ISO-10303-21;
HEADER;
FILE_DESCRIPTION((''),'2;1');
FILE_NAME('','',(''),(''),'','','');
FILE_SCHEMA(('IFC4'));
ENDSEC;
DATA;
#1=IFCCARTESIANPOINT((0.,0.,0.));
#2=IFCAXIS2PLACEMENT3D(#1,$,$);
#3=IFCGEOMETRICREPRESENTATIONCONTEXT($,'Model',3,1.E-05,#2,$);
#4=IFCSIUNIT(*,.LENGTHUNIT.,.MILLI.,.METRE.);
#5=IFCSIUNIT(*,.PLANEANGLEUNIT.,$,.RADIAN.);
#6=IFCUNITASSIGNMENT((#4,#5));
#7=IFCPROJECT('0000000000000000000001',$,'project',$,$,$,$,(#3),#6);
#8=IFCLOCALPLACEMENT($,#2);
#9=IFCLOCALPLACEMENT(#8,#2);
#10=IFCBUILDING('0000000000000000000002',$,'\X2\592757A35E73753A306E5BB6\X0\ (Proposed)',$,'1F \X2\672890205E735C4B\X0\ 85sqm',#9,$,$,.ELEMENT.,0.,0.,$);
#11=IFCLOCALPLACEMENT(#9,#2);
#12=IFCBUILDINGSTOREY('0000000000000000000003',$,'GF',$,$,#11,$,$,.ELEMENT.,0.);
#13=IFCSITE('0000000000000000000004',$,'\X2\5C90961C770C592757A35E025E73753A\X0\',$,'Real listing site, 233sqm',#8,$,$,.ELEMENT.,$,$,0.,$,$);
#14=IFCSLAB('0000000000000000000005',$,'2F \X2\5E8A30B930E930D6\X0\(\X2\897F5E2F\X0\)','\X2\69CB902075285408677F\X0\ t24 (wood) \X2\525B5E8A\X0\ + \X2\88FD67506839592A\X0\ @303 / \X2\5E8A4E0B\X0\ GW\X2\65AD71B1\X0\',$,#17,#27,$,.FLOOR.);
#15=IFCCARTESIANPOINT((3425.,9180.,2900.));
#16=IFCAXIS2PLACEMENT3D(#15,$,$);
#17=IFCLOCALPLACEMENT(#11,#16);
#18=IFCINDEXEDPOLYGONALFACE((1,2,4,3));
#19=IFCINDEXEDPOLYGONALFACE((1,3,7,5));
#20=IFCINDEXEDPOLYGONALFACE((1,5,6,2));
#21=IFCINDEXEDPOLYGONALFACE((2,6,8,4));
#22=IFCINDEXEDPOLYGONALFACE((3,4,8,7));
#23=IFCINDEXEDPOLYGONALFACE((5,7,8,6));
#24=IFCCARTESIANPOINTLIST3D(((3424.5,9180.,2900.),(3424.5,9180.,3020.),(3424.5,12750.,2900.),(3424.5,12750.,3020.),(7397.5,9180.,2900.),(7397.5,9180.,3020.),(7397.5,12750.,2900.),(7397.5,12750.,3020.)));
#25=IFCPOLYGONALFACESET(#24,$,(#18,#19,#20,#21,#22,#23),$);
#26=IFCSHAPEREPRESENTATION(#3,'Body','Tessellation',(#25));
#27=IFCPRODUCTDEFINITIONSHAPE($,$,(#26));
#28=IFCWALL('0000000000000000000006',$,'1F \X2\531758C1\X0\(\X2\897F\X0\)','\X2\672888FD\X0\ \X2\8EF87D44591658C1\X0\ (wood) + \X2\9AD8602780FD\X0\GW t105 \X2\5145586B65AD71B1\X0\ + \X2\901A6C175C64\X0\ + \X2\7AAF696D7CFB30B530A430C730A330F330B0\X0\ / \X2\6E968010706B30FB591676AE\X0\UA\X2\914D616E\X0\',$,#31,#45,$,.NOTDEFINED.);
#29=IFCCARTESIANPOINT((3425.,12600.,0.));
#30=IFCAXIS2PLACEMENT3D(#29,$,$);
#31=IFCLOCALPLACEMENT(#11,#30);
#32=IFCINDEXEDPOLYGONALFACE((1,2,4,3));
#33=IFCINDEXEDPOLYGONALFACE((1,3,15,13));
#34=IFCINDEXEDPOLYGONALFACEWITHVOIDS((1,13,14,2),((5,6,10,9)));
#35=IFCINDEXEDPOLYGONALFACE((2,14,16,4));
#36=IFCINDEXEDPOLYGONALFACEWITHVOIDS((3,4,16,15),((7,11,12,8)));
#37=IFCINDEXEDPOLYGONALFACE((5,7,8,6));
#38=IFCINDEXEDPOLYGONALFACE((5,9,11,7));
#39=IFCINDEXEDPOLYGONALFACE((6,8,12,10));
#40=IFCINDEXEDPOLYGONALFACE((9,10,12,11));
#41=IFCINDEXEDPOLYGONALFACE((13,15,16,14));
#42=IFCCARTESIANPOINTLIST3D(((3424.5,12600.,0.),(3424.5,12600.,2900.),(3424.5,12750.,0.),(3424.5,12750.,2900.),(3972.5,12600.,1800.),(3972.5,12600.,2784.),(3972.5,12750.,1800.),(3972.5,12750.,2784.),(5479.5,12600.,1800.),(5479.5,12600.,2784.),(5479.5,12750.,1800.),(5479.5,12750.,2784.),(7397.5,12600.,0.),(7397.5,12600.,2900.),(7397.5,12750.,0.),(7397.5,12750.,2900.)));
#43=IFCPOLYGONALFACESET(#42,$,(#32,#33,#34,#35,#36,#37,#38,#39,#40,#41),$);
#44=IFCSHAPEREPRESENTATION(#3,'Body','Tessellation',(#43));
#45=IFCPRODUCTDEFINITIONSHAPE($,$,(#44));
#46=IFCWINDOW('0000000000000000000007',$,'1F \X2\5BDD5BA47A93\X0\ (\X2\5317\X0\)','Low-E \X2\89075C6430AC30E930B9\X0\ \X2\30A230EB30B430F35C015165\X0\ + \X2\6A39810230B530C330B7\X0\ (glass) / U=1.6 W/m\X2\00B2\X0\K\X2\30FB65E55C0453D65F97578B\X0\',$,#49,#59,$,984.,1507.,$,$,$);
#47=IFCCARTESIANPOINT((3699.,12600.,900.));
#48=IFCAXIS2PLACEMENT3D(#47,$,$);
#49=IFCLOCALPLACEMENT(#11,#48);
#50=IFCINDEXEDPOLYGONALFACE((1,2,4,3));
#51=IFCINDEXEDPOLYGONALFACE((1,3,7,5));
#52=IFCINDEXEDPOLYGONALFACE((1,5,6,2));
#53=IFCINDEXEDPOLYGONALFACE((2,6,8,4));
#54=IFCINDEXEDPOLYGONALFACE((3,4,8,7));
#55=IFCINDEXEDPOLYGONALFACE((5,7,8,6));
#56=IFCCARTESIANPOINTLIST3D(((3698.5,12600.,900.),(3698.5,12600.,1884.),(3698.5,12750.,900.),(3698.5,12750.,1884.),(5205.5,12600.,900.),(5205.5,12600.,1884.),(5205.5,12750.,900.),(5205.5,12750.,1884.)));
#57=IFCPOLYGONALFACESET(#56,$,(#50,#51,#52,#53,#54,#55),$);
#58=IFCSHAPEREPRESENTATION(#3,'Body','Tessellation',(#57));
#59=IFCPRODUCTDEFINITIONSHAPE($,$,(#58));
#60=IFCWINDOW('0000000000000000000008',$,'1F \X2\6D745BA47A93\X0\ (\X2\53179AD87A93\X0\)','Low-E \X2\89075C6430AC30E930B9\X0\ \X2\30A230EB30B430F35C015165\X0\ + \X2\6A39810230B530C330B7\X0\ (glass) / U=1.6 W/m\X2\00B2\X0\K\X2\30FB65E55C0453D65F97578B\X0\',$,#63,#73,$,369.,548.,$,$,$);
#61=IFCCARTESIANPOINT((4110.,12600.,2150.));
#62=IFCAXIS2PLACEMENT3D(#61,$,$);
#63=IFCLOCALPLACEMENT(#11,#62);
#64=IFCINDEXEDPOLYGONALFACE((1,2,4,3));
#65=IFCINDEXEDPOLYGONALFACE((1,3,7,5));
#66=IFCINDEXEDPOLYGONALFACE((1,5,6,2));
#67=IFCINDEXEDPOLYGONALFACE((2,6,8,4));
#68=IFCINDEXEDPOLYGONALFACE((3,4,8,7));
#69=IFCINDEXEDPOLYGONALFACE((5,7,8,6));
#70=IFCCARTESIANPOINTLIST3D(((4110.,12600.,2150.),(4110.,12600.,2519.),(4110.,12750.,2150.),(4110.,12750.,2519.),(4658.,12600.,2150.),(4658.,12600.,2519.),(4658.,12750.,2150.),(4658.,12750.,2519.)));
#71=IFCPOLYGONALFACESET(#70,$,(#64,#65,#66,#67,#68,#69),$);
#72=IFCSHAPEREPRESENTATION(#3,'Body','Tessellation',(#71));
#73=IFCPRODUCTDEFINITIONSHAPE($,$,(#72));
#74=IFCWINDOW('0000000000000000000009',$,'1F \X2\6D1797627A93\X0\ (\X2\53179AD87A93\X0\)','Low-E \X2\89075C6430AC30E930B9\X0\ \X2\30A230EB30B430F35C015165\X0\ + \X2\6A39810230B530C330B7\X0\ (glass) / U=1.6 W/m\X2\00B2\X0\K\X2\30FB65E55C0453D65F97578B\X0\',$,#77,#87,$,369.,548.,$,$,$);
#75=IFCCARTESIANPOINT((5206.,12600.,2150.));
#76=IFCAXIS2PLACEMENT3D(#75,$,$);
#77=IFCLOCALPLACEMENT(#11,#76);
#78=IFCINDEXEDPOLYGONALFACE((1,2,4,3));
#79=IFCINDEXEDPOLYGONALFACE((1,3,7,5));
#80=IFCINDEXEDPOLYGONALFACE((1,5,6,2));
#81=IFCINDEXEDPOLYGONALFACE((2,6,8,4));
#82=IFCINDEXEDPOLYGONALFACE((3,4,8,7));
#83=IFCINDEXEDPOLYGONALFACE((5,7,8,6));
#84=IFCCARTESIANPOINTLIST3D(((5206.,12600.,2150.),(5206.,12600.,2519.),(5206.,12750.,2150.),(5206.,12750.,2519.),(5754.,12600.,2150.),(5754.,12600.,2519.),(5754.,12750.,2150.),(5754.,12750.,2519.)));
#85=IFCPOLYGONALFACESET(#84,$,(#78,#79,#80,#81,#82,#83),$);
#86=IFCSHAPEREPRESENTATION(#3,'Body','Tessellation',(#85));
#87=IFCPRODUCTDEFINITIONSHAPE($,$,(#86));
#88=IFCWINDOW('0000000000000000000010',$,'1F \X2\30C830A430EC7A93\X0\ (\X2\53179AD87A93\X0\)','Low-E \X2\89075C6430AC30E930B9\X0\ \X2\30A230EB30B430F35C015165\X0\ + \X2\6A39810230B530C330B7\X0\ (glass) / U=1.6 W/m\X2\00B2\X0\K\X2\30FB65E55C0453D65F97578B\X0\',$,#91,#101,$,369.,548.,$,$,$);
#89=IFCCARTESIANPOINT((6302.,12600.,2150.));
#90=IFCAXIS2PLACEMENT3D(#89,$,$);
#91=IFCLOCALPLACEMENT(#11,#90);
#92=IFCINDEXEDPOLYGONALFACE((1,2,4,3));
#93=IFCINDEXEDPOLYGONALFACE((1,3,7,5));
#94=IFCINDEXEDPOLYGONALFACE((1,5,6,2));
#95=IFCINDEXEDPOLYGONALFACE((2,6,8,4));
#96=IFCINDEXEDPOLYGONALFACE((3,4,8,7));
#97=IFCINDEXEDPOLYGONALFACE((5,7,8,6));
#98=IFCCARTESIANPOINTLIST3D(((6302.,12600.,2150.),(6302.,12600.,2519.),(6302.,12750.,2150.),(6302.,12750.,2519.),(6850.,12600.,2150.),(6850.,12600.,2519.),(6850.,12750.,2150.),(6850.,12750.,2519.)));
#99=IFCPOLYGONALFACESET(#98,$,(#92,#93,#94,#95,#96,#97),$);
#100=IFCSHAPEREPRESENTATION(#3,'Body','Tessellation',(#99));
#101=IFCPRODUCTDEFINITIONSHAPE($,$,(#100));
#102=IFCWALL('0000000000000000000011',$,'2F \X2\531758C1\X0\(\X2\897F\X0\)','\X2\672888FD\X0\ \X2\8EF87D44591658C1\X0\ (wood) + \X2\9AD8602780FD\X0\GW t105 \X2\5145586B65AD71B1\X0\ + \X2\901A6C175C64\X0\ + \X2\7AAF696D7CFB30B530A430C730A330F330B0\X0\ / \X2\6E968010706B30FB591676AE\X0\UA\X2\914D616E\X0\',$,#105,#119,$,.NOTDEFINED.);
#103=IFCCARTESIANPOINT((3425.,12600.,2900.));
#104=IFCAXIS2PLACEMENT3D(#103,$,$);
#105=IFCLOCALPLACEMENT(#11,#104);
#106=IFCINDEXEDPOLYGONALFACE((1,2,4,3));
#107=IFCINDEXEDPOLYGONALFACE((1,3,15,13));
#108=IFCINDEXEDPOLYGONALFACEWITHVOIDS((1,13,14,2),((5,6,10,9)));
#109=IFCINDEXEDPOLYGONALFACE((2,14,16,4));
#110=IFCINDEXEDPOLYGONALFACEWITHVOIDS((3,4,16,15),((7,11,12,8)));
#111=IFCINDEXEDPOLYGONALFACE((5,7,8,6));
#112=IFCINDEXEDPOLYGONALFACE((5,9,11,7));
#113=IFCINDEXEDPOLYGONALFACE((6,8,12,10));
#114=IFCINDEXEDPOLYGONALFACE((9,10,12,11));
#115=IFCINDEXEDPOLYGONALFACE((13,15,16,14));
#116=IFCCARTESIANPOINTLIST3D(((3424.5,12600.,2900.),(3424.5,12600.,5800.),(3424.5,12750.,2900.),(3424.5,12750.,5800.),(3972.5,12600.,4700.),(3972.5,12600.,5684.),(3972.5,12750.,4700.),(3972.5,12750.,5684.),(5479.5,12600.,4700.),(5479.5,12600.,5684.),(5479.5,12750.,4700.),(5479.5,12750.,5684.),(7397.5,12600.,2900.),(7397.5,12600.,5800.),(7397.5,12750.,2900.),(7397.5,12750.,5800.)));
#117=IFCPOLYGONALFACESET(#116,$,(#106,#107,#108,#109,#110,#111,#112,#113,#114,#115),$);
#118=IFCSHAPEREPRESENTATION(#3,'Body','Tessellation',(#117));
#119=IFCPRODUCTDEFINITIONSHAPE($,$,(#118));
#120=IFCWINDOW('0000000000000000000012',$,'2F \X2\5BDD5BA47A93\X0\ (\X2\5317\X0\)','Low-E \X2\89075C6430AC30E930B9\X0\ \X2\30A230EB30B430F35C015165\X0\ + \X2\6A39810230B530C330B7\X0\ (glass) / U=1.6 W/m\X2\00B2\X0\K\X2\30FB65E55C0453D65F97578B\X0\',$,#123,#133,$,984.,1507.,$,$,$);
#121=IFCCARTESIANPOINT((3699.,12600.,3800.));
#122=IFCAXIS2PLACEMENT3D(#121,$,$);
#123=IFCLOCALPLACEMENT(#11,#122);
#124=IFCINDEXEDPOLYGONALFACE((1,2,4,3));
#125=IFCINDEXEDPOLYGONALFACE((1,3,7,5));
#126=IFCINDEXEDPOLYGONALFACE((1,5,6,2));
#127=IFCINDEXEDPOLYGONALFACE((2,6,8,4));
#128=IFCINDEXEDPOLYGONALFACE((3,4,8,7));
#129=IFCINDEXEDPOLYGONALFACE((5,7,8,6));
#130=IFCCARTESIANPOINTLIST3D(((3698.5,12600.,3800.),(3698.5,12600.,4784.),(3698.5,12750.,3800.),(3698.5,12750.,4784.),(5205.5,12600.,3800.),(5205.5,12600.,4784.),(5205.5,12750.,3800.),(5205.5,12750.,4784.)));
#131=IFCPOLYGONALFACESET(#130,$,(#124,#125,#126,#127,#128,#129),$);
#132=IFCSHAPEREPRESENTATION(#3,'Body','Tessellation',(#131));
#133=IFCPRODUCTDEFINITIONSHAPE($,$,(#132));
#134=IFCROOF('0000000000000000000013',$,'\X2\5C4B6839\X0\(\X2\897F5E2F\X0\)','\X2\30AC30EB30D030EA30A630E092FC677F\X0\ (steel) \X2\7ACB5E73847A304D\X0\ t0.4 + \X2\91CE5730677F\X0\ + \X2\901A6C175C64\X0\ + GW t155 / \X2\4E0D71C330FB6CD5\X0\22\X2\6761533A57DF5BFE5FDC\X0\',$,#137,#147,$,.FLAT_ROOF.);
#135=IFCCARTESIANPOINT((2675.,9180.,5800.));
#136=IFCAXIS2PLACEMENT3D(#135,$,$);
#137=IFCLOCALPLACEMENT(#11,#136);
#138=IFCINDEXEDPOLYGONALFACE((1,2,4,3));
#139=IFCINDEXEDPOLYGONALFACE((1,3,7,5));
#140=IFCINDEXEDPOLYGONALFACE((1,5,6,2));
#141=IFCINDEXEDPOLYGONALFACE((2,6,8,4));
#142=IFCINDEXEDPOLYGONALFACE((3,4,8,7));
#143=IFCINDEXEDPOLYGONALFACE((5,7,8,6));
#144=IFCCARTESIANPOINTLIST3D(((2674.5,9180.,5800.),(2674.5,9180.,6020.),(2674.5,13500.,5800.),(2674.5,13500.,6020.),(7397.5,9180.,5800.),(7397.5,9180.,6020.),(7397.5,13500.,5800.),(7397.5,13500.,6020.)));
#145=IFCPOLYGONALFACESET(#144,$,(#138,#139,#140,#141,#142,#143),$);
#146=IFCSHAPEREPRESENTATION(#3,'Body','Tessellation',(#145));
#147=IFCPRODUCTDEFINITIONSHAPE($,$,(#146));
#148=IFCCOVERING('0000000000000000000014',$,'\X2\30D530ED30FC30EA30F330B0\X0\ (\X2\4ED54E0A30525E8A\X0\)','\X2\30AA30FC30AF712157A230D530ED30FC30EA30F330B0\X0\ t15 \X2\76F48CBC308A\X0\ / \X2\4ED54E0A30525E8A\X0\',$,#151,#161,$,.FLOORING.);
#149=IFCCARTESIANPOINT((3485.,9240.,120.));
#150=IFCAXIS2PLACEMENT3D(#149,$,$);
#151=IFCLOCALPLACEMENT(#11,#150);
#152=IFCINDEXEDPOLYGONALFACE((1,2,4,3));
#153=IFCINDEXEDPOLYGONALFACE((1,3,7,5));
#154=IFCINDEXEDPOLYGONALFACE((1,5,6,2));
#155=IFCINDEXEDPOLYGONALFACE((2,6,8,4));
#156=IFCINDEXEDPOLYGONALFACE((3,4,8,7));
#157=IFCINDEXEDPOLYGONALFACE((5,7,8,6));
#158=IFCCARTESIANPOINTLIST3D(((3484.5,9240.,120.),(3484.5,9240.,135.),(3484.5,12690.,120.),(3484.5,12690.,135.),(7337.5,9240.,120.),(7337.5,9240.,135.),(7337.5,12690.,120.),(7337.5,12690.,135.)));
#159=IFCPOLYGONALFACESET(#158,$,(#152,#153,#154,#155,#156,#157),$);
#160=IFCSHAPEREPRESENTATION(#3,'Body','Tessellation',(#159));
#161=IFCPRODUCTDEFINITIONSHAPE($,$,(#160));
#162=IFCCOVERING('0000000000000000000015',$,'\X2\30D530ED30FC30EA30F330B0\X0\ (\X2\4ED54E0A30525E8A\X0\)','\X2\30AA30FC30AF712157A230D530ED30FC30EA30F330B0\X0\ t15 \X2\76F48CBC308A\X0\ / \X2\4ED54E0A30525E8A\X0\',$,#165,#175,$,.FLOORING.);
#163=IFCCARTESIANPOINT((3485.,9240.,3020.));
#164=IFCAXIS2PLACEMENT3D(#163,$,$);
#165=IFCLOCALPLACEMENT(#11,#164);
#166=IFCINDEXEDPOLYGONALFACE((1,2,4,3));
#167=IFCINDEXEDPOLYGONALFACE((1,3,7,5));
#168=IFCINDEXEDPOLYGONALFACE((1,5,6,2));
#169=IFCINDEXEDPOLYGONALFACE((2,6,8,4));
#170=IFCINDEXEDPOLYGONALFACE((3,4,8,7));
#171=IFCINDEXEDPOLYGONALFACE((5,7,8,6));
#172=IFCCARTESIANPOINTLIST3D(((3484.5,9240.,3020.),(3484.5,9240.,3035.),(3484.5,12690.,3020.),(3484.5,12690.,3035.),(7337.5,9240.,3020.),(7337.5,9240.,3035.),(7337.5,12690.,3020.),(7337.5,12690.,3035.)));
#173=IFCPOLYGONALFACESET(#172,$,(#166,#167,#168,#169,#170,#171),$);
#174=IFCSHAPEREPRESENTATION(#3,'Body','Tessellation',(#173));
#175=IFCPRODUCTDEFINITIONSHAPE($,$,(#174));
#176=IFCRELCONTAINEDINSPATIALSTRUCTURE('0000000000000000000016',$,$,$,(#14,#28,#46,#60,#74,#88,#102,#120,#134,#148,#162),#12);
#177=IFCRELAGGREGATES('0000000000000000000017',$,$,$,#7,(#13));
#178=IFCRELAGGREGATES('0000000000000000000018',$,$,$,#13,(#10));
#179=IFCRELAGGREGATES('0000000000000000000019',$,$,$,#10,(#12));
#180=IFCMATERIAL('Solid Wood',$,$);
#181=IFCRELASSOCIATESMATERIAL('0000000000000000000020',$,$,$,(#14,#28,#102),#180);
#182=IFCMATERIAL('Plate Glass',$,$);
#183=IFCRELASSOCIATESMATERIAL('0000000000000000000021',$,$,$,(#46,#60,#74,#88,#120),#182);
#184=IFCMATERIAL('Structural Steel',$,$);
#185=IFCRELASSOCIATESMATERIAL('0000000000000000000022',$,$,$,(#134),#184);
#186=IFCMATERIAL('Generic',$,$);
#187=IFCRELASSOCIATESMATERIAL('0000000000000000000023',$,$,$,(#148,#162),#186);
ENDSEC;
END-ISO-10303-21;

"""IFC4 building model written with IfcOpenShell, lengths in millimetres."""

from ifc_helpers import new_model, si_unit, frame, frame_2d, origin, place, context, project, spatial, rectangle, extrude, material, element, fill, save


model = new_model("IFC4")

# Units and contexts
model_context = context("Model", 3, precision=1e-05, world=origin())
ifc_project = project(units=[si_unit("LENGTHUNIT", "METRE", prefix="MILLI"), si_unit("PLANEANGLEUNIT", "RADIAN")], contexts=[model_context])

# Site, building, storey
site_placement = place(None, origin())
site = spatial("IfcSite", under=ifc_project, at=site_placement, Name="岐阜県大垣市平町", ObjectType="Real listing site, 233sqm", CompositionType="ELEMENT", RefElevation=0.0)
building_placement = place(site_placement, origin())
building = spatial("IfcBuilding", under=site, at=building_placement, Name="大垣平町の家 (Proposed)", ObjectType="1F 木造平屋 85sqm", CompositionType="ELEMENT", ElevationOfRefHeight=0.0, ElevationOfTerrain=0.0)
storey_placement = place(building_placement, origin())
storey = spatial("IfcBuildingStorey", under=building, at=storey_placement, Name="GF", CompositionType="ELEMENT", Elevation=0.0)

# Slab
ifc_material_1 = material(Name="Solid Wood")
slab_1_placement = place(storey_placement, frame((3425.0, 9180.0, 2900.0)))
element("IfcSlab", 1, at=slab_1_placement, inside=storey, material=ifc_material_1, Name="2F 床スラブ(西帯)", Description="構造用合板 t24 (wood) 剛床 + 製材根太 @303 / 床下 GW断熱", PredefinedType="FLOOR", context=model_context, shape_type="SweptSolid", body=[
    extrude(rectangle(XDim=3973.0, YDim=3570.0, at=frame_2d((1986.0, 1785.0))), frame((3425.0, 9180.0, 2900.0)), (0.0, 0.0, 1.0), 120.0),
])

# Wall, openings, windows
wall_1_placement = place(storey_placement, frame((3425.0, 12600.0, 0.0)))
wall_1 = element("IfcWall", 2, at=wall_1_placement, inside=storey, material=ifc_material_1, Name="1F 北壁(西)", Description="木製 軸組外壁 (wood) + 高性能GW t105 充填断熱 + 通気層 + 窯業系サイディング / 準耐火・外皮UA配慮", PredefinedType="NOTDEFINED", context=model_context, shape_type="SweptSolid", body=[
    extrude(rectangle(XDim=3973.0, YDim=150.0, at=frame_2d((1986.0, 75.0))), frame((3425.0, 12600.0, 0.0)), (0.0, 0.0, 1.0), 2900.0),
])
opening_1_placement = place(storey_placement, frame((3699.0, 12600.0, 900.0)))
opening_1 = element("IfcOpeningElement", 3, at=opening_1_placement, cuts=wall_1, PredefinedType="NOTDEFINED", context=model_context, shape_type="SweptSolid", body=[
    extrude(rectangle(XDim=1507.0, YDim=150.0, at=frame_2d((753.0, 75.0))), frame((3699.0, 12600.0, 900.0)), (0.0, 0.0, 1.0), 984.0),
])
opening_2_placement = place(storey_placement, frame((4110.0, 12600.0, 2150.0)))
opening_2 = element("IfcOpeningElement", 4, at=opening_2_placement, cuts=wall_1, PredefinedType="NOTDEFINED", context=model_context, shape_type="SweptSolid", body=[
    extrude(rectangle(XDim=548.0, YDim=150.0, at=frame_2d((274.0, 75.0))), frame((4110.0, 12600.0, 2150.0)), (0.0, 0.0, 1.0), 369.0),
])
opening_3_placement = place(storey_placement, frame((5206.0, 12600.0, 2150.0)))
opening_3 = element("IfcOpeningElement", 5, at=opening_3_placement, cuts=wall_1, PredefinedType="NOTDEFINED", context=model_context, shape_type="SweptSolid", body=[
    extrude(rectangle(XDim=548.0, YDim=150.0, at=frame_2d((274.0, 75.0))), frame((5206.0, 12600.0, 2150.0)), (0.0, 0.0, 1.0), 369.0),
])
opening_4_placement = place(storey_placement, frame((6302.0, 12600.0, 2150.0)))
opening_4 = element("IfcOpeningElement", 6, at=opening_4_placement, cuts=wall_1, PredefinedType="NOTDEFINED", context=model_context, shape_type="SweptSolid", body=[
    extrude(rectangle(XDim=548.0, YDim=150.0, at=frame_2d((274.0, 75.0))), frame((6302.0, 12600.0, 2150.0)), (0.0, 0.0, 1.0), 369.0),
])
ifc_material_2 = material(Name="Plate Glass")
window_1_placement = place(storey_placement, frame((3699.0, 12600.0, 900.0)))
window_1 = element("IfcWindow", 7, at=window_1_placement, inside=storey, material=ifc_material_2, Name="1F 寝室窓 (北)", Description="Low-E 複層ガラス アルゴン封入 + 樹脂サッシ (glass) / U=1.6 W/m²K・日射取得型", OverallHeight=984.0, OverallWidth=1507.0, context=model_context, shape_type="SweptSolid", body=[
    extrude(rectangle(XDim=1507.0, YDim=150.0, at=frame_2d((753.0, 75.0))), frame((3699.0, 12600.0, 900.0)), (0.0, 0.0, 1.0), 984.0),
])
fill(opening_1, window_1)
window_2_placement = place(storey_placement, frame((4110.0, 12600.0, 2150.0)))
window_2 = element("IfcWindow", 8, at=window_2_placement, inside=storey, material=ifc_material_2, Name="1F 浴室窓 (北高窓)", Description="Low-E 複層ガラス アルゴン封入 + 樹脂サッシ (glass) / U=1.6 W/m²K・日射取得型", OverallHeight=369.0, OverallWidth=548.0, context=model_context, shape_type="SweptSolid", body=[
    extrude(rectangle(XDim=548.0, YDim=150.0, at=frame_2d((274.0, 75.0))), frame((4110.0, 12600.0, 2150.0)), (0.0, 0.0, 1.0), 369.0),
])
fill(opening_2, window_2)
window_3_placement = place(storey_placement, frame((5206.0, 12600.0, 2150.0)))
window_3 = element("IfcWindow", 9, at=window_3_placement, inside=storey, material=ifc_material_2, Name="1F 洗面窓 (北高窓)", Description="Low-E 複層ガラス アルゴン封入 + 樹脂サッシ (glass) / U=1.6 W/m²K・日射取得型", OverallHeight=369.0, OverallWidth=548.0, context=model_context, shape_type="SweptSolid", body=[
    extrude(rectangle(XDim=548.0, YDim=150.0, at=frame_2d((274.0, 75.0))), frame((5206.0, 12600.0, 2150.0)), (0.0, 0.0, 1.0), 369.0),
])
fill(opening_3, window_3)
window_4_placement = place(storey_placement, frame((6302.0, 12600.0, 2150.0)))
window_4 = element("IfcWindow", 10, at=window_4_placement, inside=storey, material=ifc_material_2, Name="1F トイレ窓 (北高窓)", Description="Low-E 複層ガラス アルゴン封入 + 樹脂サッシ (glass) / U=1.6 W/m²K・日射取得型", OverallHeight=369.0, OverallWidth=548.0, context=model_context, shape_type="SweptSolid", body=[
    extrude(rectangle(XDim=548.0, YDim=150.0, at=frame_2d((274.0, 75.0))), frame((6302.0, 12600.0, 2150.0)), (0.0, 0.0, 1.0), 369.0),
])
fill(opening_4, window_4)

# Wall, opening, window
wall_2_placement = place(storey_placement, frame((3425.0, 12600.0, 2900.0)))
wall_2 = element("IfcWall", 11, at=wall_2_placement, inside=storey, material=ifc_material_1, Name="2F 北壁(西)", Description="木製 軸組外壁 (wood) + 高性能GW t105 充填断熱 + 通気層 + 窯業系サイディング / 準耐火・外皮UA配慮", PredefinedType="NOTDEFINED", context=model_context, shape_type="SweptSolid", body=[
    extrude(rectangle(XDim=3973.0, YDim=150.0, at=frame_2d((1986.0, 75.0))), frame((3425.0, 12600.0, 2900.0)), (0.0, 0.0, 1.0), 2900.0),
])
opening_5_placement = place(storey_placement, frame((3699.0, 12600.0, 3800.0)))
opening_5 = element("IfcOpeningElement", 12, at=opening_5_placement, cuts=wall_2, PredefinedType="NOTDEFINED", context=model_context, shape_type="SweptSolid", body=[
    extrude(rectangle(XDim=1507.0, YDim=150.0, at=frame_2d((753.0, 75.0))), frame((3699.0, 12600.0, 3800.0)), (0.0, 0.0, 1.0), 984.0),
])
window_5_placement = place(storey_placement, frame((3699.0, 12600.0, 3800.0)))
window_5 = element("IfcWindow", 13, at=window_5_placement, inside=storey, material=ifc_material_2, Name="2F 寝室窓 (北)", Description="Low-E 複層ガラス アルゴン封入 + 樹脂サッシ (glass) / U=1.6 W/m²K・日射取得型", OverallHeight=984.0, OverallWidth=1507.0, context=model_context, shape_type="SweptSolid", body=[
    extrude(rectangle(XDim=1507.0, YDim=150.0, at=frame_2d((753.0, 75.0))), frame((3699.0, 12600.0, 3800.0)), (0.0, 0.0, 1.0), 984.0),
])
fill(opening_5, window_5)

# Roof
ifc_material_3 = material(Name="Structural Steel")
for number, where, name in (
    (14, (2675.0, 9180.0, 5800.0), "屋根(西帯)"),
):
    element("IfcRoof", number, at=place(storey_placement, frame(where)), inside=storey, material=ifc_material_3, Name=name, Description="ガルバリウム鋼板 (steel) 立平葺き t0.4 + 野地板 + 通気層 + GW t155 / 不燃・法22条区域対応", PredefinedType="FLAT_ROOF", context=model_context, shape_type="SweptSolid", body=[
        extrude(rectangle(XDim=4723.0, YDim=4320.0, at=frame_2d((2361.0, 2160.0))), frame((2675.0, 9180.0, 5800.0)), (0.0, 0.0, 1.0), 220.0),
    ])

# Coverings
ifc_material_4 = material(Name="Generic")
covering_1_placement = place(storey_placement, frame((3485.0, 9240.0, 120.0)))
element("IfcCovering", 15, at=covering_1_placement, inside=storey, material=ifc_material_4, Name="フローリング (仕上げ床)", Description="オーク無垢フローリング t15 直貼り / 仕上げ床", PredefinedType="FLOORING", context=model_context, shape_type="SweptSolid", body=[
    extrude(rectangle(XDim=3853.0, YDim=3450.0, at=frame_2d((1926.0, 1725.0))), frame((3485.0, 9240.0, 120.0)), (0.0, 0.0, 1.0), 15.0),
])
covering_2_placement = place(storey_placement, frame((3485.0, 9240.0, 3020.0)))
element("IfcCovering", 16, at=covering_2_placement, inside=storey, material=ifc_material_4, Name="フローリング (仕上げ床)", Description="オーク無垢フローリング t15 直貼り / 仕上げ床", PredefinedType="FLOORING", context=model_context, shape_type="SweptSolid", body=[
    extrude(rectangle(XDim=3853.0, YDim=3450.0, at=frame_2d((1926.0, 1725.0))), frame((3485.0, 9240.0, 3020.0)), (0.0, 0.0, 1.0), 15.0),
])

save(model, "model.ifc")
